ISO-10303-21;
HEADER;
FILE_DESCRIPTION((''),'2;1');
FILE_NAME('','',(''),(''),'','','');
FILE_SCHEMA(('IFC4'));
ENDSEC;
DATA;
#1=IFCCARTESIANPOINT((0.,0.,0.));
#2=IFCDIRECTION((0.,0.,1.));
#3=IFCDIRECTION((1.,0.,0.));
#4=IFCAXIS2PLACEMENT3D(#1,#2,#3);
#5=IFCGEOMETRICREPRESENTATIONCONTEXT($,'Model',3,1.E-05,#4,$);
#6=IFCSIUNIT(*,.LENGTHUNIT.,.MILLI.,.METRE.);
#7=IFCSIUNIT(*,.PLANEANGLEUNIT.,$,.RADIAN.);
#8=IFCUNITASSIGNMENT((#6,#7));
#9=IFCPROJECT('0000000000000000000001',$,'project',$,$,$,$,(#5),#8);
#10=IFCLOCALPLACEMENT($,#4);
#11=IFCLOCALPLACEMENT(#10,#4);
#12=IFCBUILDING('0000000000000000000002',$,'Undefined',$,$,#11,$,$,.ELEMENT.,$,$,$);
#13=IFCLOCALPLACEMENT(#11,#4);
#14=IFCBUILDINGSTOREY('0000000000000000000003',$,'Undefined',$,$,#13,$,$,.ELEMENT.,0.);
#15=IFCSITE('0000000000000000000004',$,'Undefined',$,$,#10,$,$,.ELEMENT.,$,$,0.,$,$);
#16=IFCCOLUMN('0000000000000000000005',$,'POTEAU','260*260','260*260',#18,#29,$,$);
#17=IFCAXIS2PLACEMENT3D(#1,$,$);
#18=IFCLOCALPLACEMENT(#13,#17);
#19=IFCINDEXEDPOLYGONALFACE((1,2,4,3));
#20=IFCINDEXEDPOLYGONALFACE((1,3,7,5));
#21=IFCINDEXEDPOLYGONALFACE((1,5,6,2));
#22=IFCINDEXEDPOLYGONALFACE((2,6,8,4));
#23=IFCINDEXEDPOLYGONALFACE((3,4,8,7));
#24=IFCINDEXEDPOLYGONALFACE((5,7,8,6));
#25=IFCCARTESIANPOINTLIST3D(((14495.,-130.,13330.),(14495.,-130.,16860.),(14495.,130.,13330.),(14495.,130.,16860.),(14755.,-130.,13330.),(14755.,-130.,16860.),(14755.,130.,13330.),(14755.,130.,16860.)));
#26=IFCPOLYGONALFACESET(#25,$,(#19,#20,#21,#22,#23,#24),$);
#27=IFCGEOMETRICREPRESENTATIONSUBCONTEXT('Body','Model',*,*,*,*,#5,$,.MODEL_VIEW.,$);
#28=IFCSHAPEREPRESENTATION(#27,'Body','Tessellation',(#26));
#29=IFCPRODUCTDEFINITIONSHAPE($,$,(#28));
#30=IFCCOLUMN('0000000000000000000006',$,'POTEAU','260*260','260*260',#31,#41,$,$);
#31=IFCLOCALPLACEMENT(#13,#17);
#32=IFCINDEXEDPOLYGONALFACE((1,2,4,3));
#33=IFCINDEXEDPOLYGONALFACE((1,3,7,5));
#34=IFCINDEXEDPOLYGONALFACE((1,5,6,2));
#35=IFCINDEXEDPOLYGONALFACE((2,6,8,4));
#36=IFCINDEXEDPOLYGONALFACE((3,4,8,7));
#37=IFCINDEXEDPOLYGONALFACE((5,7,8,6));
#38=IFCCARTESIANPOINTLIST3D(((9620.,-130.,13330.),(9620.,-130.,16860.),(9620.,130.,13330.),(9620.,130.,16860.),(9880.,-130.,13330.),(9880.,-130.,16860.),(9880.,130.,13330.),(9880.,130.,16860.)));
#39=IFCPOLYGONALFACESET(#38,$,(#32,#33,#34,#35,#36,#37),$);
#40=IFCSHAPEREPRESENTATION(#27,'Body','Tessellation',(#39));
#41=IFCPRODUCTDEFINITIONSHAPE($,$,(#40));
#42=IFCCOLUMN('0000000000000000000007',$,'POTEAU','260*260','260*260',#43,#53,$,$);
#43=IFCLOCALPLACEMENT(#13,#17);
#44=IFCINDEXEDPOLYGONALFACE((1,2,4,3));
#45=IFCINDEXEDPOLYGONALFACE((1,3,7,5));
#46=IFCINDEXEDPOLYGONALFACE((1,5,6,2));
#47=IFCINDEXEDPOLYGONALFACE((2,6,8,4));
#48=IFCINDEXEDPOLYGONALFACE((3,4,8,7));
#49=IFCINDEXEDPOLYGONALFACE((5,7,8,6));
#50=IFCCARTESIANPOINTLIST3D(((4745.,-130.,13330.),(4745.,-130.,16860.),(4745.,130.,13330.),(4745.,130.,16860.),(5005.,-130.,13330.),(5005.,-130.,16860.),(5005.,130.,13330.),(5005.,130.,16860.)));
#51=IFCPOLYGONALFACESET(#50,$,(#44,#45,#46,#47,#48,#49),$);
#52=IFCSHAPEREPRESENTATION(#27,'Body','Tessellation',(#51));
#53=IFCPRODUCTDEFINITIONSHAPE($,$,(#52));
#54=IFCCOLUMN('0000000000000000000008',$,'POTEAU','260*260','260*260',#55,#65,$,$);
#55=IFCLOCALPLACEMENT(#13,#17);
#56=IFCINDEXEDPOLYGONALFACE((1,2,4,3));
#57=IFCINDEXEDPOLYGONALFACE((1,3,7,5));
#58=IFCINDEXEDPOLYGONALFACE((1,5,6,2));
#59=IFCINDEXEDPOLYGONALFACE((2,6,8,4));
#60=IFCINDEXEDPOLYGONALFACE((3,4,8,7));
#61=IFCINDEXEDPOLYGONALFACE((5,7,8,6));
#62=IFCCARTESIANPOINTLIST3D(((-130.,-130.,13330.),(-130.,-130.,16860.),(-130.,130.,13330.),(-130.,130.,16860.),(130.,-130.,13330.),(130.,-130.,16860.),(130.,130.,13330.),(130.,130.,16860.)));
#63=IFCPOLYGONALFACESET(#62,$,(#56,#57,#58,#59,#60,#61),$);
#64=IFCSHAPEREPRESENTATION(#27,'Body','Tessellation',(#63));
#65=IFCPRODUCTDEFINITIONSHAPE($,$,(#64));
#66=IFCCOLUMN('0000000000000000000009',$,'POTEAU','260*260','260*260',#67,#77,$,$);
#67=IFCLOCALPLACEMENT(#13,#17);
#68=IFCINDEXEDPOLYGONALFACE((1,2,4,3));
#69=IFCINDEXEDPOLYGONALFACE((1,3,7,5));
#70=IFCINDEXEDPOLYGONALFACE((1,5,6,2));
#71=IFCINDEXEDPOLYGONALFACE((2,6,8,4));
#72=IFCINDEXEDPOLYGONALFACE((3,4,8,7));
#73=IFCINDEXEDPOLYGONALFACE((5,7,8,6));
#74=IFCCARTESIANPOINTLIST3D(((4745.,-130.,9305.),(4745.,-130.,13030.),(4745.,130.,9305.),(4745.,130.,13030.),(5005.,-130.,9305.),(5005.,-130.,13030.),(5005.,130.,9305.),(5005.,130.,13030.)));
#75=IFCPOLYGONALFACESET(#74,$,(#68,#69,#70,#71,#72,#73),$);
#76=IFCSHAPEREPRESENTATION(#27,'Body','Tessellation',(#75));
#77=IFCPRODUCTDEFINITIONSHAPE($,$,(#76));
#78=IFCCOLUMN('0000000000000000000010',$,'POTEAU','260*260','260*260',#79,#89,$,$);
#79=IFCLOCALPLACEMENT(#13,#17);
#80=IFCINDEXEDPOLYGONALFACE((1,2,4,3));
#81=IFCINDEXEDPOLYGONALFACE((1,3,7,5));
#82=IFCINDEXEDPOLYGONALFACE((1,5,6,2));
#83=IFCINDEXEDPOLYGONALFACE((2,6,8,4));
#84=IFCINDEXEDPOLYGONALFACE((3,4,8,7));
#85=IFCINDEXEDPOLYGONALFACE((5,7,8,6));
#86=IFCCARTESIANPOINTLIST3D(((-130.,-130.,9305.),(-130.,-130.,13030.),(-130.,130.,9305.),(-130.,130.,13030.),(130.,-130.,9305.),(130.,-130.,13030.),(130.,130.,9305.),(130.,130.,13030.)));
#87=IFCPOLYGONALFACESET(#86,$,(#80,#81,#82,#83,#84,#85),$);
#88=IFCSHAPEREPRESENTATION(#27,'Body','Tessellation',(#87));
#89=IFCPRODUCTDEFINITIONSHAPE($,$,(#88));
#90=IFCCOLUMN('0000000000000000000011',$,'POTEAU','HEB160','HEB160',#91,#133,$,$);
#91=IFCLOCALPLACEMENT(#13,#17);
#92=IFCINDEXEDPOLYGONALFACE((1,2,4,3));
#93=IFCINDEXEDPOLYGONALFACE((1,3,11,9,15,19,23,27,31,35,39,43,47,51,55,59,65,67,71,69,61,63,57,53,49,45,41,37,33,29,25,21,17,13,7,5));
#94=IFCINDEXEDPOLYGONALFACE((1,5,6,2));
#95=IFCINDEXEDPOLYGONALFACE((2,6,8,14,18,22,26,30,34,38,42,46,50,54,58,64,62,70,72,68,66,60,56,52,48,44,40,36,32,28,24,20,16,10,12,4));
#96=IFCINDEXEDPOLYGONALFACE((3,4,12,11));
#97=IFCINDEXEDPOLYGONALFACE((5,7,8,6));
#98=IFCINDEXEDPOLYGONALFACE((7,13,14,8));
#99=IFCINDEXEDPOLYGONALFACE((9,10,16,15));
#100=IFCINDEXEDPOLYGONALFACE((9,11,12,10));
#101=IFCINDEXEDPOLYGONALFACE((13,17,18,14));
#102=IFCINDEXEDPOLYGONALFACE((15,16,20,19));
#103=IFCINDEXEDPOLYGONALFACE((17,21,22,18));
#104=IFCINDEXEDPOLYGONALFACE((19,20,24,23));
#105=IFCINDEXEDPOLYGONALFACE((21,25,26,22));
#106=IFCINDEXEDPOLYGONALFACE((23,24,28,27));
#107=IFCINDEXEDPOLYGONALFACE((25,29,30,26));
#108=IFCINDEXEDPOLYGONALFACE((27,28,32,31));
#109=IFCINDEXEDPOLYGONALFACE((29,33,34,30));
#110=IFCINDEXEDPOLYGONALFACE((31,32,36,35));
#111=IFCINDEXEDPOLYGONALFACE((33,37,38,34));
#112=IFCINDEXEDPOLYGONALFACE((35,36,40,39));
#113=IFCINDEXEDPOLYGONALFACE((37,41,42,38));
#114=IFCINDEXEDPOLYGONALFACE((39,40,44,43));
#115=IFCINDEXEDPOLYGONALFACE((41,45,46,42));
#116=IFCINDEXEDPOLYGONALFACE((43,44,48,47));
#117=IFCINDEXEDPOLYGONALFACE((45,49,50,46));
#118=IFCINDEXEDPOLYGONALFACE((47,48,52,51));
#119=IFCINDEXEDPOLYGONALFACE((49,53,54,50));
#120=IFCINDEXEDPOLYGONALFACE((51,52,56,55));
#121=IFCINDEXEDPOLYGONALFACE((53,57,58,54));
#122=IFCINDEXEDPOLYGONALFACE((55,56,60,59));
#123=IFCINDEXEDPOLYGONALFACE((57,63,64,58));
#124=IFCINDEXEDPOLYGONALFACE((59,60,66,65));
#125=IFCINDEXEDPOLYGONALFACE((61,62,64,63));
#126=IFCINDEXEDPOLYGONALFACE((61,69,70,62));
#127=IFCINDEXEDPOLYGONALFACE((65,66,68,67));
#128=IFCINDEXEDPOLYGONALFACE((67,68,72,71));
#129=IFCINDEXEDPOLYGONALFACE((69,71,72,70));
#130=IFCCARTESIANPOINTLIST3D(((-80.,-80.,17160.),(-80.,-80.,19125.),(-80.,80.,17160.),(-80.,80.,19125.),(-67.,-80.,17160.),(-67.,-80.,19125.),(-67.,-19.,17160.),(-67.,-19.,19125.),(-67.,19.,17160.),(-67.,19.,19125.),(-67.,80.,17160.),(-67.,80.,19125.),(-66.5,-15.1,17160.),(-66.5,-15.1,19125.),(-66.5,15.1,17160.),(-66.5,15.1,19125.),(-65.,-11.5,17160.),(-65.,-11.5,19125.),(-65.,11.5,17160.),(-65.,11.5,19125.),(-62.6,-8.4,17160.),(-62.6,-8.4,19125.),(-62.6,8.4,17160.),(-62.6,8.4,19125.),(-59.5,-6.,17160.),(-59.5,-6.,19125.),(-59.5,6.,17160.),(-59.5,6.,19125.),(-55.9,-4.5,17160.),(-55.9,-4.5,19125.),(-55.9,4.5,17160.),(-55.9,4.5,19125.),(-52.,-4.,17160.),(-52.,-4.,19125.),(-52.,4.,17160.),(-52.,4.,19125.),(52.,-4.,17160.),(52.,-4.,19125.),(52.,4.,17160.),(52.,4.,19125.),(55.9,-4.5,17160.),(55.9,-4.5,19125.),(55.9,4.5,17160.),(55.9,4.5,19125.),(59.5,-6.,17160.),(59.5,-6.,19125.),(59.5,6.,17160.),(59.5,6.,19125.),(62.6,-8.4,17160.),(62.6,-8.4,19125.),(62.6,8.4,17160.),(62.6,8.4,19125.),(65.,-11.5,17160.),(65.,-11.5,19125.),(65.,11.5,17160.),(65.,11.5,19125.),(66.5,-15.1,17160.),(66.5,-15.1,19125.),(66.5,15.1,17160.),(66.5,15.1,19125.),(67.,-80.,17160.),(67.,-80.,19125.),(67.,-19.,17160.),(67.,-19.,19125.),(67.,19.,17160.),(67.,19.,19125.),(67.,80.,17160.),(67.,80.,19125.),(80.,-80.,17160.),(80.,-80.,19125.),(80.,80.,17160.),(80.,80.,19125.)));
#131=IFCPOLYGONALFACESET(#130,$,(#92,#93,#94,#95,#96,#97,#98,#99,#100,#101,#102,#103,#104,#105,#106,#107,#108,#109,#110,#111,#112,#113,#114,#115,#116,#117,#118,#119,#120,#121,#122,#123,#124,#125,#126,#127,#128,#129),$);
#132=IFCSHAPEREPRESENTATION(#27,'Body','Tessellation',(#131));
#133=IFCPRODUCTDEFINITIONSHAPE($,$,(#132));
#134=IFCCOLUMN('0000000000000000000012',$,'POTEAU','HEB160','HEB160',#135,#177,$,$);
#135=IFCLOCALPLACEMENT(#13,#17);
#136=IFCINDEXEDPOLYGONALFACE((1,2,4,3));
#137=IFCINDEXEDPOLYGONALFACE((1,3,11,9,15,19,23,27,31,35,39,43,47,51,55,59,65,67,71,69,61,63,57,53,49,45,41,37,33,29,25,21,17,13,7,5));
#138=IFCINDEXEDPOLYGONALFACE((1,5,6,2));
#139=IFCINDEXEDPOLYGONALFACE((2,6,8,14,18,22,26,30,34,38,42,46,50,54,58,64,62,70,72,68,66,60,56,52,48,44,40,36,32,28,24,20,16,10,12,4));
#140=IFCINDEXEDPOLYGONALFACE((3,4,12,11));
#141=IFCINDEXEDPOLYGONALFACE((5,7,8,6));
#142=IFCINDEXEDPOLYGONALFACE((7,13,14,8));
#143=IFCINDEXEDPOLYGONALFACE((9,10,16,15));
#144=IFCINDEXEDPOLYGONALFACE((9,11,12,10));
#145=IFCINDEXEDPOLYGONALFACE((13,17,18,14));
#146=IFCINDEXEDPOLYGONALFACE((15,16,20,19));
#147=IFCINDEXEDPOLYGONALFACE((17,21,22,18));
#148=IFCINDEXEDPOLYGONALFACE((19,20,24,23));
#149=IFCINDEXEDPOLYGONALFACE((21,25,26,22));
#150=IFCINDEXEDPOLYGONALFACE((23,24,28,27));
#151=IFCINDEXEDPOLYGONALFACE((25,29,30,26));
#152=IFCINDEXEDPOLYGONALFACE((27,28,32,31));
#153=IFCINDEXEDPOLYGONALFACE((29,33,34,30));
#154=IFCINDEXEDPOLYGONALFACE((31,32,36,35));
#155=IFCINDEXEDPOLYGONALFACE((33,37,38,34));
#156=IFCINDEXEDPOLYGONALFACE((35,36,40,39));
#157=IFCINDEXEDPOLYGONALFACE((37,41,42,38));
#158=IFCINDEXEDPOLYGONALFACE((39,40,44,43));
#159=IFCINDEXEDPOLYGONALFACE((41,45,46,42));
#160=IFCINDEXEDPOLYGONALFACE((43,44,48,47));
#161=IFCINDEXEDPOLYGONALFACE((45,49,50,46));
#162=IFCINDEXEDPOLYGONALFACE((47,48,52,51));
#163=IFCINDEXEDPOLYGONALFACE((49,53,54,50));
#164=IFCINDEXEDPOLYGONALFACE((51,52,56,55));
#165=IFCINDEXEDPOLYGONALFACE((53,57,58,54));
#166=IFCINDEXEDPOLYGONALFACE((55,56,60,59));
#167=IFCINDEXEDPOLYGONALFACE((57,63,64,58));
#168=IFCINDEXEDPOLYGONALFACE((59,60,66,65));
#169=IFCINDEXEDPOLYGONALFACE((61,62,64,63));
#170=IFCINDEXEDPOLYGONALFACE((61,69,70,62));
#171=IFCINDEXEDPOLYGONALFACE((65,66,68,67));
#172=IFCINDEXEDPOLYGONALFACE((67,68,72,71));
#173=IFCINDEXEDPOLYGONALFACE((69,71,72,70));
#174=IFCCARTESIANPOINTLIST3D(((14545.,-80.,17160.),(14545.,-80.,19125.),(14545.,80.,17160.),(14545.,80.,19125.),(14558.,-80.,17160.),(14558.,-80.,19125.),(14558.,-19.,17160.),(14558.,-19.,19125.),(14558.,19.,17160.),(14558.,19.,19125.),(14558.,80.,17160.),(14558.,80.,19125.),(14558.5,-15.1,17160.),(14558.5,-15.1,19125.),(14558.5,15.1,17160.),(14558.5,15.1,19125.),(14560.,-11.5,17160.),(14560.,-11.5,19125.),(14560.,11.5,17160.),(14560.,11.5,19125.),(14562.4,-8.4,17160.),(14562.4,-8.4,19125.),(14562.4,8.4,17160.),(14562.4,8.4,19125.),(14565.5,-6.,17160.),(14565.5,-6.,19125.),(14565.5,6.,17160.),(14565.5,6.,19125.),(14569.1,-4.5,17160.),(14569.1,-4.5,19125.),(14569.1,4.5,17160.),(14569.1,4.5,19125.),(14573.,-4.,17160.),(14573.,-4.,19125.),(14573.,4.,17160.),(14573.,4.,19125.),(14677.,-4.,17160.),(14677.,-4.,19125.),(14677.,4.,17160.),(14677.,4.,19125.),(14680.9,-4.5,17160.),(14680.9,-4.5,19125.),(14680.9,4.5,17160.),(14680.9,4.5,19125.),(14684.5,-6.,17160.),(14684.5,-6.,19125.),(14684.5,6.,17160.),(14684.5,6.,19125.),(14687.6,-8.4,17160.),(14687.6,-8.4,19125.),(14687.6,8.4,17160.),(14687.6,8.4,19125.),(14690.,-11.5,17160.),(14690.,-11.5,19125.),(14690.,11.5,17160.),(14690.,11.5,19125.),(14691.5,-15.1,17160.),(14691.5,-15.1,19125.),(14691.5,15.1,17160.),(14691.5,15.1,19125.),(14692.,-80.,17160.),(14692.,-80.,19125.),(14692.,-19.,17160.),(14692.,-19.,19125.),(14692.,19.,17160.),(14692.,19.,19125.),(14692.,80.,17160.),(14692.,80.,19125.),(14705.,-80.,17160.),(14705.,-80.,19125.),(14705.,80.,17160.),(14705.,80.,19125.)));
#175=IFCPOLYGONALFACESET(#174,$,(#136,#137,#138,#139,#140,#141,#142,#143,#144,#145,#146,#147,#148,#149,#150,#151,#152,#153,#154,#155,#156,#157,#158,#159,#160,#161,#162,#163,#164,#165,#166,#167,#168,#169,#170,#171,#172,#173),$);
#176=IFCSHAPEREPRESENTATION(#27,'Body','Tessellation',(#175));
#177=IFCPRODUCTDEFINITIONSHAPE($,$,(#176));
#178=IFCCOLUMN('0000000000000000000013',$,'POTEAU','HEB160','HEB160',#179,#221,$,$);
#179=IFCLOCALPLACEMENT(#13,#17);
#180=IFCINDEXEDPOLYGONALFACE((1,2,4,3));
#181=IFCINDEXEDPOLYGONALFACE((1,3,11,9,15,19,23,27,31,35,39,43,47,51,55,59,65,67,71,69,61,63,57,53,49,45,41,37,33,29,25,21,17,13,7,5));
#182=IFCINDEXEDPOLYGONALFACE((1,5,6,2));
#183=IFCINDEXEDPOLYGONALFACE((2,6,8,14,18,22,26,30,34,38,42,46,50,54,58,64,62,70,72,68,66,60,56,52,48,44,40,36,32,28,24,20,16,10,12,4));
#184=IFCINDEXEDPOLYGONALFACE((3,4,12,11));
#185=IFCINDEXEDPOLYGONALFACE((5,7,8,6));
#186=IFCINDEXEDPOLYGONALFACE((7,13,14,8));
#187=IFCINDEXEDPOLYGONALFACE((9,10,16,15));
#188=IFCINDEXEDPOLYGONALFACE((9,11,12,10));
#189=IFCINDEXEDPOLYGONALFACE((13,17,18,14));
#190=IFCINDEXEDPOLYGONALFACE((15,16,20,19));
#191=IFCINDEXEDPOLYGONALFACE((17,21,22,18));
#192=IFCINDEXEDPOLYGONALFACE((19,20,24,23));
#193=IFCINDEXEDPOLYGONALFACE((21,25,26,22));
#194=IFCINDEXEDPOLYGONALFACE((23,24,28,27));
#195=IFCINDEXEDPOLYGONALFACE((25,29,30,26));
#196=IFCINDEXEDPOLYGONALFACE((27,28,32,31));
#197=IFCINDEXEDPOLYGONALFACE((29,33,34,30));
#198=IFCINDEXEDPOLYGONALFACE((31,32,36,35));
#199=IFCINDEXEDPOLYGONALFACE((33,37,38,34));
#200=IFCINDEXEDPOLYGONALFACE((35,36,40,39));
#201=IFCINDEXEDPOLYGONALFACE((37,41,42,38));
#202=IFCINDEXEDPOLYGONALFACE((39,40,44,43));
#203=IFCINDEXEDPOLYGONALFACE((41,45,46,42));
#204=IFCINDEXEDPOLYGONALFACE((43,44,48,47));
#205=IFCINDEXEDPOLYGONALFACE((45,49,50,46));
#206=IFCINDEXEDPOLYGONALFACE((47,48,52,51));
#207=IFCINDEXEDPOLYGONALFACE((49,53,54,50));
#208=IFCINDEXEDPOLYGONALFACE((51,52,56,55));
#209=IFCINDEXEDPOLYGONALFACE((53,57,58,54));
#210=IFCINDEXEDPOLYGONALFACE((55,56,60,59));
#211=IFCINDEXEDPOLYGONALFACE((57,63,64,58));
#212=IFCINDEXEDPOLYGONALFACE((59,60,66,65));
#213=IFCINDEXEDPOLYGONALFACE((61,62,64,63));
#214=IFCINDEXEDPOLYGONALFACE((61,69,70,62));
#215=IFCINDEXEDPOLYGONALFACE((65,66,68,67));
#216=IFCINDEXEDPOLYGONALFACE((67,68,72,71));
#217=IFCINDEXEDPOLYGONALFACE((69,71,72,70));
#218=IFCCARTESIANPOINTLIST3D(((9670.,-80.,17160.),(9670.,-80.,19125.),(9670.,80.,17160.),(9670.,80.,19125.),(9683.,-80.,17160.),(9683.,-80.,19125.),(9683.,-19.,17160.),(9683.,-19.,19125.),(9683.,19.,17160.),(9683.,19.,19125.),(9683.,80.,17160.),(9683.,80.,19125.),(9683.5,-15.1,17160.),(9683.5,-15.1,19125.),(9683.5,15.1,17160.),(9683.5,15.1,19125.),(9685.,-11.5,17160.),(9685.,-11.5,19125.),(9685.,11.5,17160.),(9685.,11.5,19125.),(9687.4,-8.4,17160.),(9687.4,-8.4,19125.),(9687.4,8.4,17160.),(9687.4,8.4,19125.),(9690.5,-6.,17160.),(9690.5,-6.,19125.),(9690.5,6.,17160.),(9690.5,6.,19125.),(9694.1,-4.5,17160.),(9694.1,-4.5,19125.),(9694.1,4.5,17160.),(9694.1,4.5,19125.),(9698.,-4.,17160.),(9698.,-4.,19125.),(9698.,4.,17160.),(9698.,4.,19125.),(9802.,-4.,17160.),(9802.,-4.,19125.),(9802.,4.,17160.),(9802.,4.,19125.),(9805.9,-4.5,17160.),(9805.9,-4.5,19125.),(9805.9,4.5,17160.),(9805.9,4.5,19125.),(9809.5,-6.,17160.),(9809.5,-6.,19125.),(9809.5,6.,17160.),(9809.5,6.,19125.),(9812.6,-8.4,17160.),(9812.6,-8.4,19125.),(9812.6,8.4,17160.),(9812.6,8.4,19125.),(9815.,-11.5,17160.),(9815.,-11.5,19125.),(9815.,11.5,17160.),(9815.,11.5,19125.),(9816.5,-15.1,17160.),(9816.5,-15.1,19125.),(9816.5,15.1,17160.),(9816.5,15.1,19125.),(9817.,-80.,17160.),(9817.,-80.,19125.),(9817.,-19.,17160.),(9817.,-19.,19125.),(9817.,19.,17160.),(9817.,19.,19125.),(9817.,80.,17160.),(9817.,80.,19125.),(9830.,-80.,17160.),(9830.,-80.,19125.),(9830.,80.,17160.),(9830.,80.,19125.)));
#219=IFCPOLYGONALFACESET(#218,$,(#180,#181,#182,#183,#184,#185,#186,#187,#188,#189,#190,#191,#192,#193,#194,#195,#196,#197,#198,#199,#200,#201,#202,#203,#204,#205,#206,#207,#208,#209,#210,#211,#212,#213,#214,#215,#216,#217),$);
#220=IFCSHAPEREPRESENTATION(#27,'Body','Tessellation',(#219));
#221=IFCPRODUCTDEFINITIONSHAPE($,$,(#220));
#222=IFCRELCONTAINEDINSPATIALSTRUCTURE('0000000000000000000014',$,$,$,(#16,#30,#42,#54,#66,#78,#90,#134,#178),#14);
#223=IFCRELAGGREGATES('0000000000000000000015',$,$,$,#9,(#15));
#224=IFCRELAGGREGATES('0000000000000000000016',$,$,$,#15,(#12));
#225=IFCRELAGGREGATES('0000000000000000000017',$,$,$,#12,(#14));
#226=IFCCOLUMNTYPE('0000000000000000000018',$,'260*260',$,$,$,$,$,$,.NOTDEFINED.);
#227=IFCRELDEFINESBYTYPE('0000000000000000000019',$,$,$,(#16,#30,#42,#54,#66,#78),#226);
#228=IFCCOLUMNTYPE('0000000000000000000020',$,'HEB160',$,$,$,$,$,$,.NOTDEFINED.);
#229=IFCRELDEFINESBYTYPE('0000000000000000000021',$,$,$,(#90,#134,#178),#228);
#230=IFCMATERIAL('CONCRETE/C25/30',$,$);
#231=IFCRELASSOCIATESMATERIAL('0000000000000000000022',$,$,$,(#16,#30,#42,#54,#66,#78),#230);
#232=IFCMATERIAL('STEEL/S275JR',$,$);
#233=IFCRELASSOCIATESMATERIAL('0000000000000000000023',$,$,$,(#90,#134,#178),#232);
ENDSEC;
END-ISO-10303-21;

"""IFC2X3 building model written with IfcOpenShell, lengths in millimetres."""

from ifc_helpers import new_model, si_unit, frame, origin_with_axes, origin_2d_with_axis, place, context, subcontext, project, spatial, rectangle, i_section, extrude, material, type_object, element, save


model = new_model("IFC2X3")

# Units and contexts
model_context = context("Model", 3, precision=1e-05, world=origin_with_axes())
body_context = subcontext(model_context, "Body", "Model", "MODEL_VIEW")
ifc_project = project(units=[si_unit("LENGTHUNIT", "METRE", prefix="MILLI"), si_unit("PLANEANGLEUNIT", "RADIAN")], contexts=[model_context])

# Site, building, storey
site_placement = place(None, origin_with_axes())
site = spatial("IfcSite", under=ifc_project, at=site_placement, Name="Undefined", CompositionType="ELEMENT", RefElevation=0.0)
building_placement = place(site_placement, origin_with_axes())
building = spatial("IfcBuilding", under=site, at=building_placement, Name="Undefined", CompositionType="ELEMENT")
storey_placement = place(building_placement, origin_with_axes())
storey = spatial("IfcBuildingStorey", under=building, at=storey_placement, Name="Undefined", CompositionType="ELEMENT", Elevation=0.0)

# Columns
ifc_material_1 = material(Name="CONCRETE/C25/30")
column_type_1 = type_object("IfcColumnType", Name="260*260", PredefinedType="NOTDEFINED")
for number, where, z_axis, x_axis, name in (
    (1, (14625.0, 0.0, 13330.0), (0.0, 0.0, 1.0), (1.0, 0.0, 0.0), "POTEAU"),
    (2, (9750.0, 0.0, 13330.0), (0.0, 0.0, 1.0), (1.0, 0.0, 0.0), "POTEAU"),
    (3, (4875.0, 0.0, 13330.0), (0.0, 0.0, 1.0), (1.0, 0.0, 0.0), "POTEAU"),
    (4, (0.0, 0.0, 13330.0), (0.0, 0.0, 1.0), (1.0, 0.0, 0.0), "POTEAU"),
):
    element("IfcColumn", number, at=place(storey_placement, frame(where, z_axis=z_axis, x_axis=x_axis)), inside=storey, type_object=column_type_1, material=ifc_material_1, Name=name, Description="260*260", ObjectType="260*260", context=body_context, shape_type="SweptSolid", body=[
        extrude(rectangle(XDim=260.0, YDim=260.0, at=origin_2d_with_axis()), frame((0.0, 0.0, 3530.0), z_axis=(0.0, 0.0, -1.0), x_axis=(-1.0, 0.0, 0.0)), (0.0, 0.0, 1.0), 3530.0),
    ])
for number, where, z_axis, x_axis, name in (
    (5, (4875.0, 0.0, 9305.0), (0.0, 0.0, 1.0), (1.0, 0.0, 0.0), "POTEAU"),
    (6, (0.0, 0.0, 9305.0), (0.0, 0.0, 1.0), (1.0, 0.0, 0.0), "POTEAU"),
):
    element("IfcColumn", number, at=place(storey_placement, frame(where, z_axis=z_axis, x_axis=x_axis)), inside=storey, type_object=column_type_1, material=ifc_material_1, Name=name, Description="260*260", ObjectType="260*260", context=body_context, shape_type="SweptSolid", body=[
        extrude(rectangle(XDim=260.0, YDim=260.0, at=origin_2d_with_axis()), frame((0.0, 0.0, 3725.0), z_axis=(0.0, 0.0, -1.0), x_axis=(-1.0, 0.0, 0.0)), (0.0, 0.0, 1.0), 3725.0),
    ])
ifc_material_2 = material(Name="STEEL/S275JR")
column_type_2 = type_object("IfcColumnType", Name="HEB160", PredefinedType="NOTDEFINED")
for number, where, z_axis, x_axis, name in (
    (7, (0.0, 0.0, 17160.0), (0.0, 0.0, 1.0), (1.0, 0.0, 0.0), "POTEAU"),
    (8, (14625.0, 0.0, 17160.0), (0.0, 0.0, 1.0), (1.0, 0.0, 0.0), "POTEAU"),
    (9, (9750.0, 0.0, 17160.0), (0.0, 0.0, 1.0), (1.0, 0.0, 0.0), "POTEAU"),
):
    element("IfcColumn", number, at=place(storey_placement, frame(where, z_axis=z_axis, x_axis=x_axis)), inside=storey, type_object=column_type_2, material=ifc_material_2, Name=name, Description="HEB160", ObjectType="HEB160", context=body_context, shape_type="SweptSolid", body=[
        extrude(i_section(OverallWidth=160.0, OverallDepth=160.0, WebThickness=8.0, FlangeThickness=13.0, FilletRadius=15.0, at=origin_2d_with_axis()), frame((0.0, 0.0, 1965.0), z_axis=(0.0, 0.0, -1.0), x_axis=(0.0, -1.0, 0.0)), (0.0, 0.0, 1.0), 1965.0),
    ])

save(model, "model.ifc")
